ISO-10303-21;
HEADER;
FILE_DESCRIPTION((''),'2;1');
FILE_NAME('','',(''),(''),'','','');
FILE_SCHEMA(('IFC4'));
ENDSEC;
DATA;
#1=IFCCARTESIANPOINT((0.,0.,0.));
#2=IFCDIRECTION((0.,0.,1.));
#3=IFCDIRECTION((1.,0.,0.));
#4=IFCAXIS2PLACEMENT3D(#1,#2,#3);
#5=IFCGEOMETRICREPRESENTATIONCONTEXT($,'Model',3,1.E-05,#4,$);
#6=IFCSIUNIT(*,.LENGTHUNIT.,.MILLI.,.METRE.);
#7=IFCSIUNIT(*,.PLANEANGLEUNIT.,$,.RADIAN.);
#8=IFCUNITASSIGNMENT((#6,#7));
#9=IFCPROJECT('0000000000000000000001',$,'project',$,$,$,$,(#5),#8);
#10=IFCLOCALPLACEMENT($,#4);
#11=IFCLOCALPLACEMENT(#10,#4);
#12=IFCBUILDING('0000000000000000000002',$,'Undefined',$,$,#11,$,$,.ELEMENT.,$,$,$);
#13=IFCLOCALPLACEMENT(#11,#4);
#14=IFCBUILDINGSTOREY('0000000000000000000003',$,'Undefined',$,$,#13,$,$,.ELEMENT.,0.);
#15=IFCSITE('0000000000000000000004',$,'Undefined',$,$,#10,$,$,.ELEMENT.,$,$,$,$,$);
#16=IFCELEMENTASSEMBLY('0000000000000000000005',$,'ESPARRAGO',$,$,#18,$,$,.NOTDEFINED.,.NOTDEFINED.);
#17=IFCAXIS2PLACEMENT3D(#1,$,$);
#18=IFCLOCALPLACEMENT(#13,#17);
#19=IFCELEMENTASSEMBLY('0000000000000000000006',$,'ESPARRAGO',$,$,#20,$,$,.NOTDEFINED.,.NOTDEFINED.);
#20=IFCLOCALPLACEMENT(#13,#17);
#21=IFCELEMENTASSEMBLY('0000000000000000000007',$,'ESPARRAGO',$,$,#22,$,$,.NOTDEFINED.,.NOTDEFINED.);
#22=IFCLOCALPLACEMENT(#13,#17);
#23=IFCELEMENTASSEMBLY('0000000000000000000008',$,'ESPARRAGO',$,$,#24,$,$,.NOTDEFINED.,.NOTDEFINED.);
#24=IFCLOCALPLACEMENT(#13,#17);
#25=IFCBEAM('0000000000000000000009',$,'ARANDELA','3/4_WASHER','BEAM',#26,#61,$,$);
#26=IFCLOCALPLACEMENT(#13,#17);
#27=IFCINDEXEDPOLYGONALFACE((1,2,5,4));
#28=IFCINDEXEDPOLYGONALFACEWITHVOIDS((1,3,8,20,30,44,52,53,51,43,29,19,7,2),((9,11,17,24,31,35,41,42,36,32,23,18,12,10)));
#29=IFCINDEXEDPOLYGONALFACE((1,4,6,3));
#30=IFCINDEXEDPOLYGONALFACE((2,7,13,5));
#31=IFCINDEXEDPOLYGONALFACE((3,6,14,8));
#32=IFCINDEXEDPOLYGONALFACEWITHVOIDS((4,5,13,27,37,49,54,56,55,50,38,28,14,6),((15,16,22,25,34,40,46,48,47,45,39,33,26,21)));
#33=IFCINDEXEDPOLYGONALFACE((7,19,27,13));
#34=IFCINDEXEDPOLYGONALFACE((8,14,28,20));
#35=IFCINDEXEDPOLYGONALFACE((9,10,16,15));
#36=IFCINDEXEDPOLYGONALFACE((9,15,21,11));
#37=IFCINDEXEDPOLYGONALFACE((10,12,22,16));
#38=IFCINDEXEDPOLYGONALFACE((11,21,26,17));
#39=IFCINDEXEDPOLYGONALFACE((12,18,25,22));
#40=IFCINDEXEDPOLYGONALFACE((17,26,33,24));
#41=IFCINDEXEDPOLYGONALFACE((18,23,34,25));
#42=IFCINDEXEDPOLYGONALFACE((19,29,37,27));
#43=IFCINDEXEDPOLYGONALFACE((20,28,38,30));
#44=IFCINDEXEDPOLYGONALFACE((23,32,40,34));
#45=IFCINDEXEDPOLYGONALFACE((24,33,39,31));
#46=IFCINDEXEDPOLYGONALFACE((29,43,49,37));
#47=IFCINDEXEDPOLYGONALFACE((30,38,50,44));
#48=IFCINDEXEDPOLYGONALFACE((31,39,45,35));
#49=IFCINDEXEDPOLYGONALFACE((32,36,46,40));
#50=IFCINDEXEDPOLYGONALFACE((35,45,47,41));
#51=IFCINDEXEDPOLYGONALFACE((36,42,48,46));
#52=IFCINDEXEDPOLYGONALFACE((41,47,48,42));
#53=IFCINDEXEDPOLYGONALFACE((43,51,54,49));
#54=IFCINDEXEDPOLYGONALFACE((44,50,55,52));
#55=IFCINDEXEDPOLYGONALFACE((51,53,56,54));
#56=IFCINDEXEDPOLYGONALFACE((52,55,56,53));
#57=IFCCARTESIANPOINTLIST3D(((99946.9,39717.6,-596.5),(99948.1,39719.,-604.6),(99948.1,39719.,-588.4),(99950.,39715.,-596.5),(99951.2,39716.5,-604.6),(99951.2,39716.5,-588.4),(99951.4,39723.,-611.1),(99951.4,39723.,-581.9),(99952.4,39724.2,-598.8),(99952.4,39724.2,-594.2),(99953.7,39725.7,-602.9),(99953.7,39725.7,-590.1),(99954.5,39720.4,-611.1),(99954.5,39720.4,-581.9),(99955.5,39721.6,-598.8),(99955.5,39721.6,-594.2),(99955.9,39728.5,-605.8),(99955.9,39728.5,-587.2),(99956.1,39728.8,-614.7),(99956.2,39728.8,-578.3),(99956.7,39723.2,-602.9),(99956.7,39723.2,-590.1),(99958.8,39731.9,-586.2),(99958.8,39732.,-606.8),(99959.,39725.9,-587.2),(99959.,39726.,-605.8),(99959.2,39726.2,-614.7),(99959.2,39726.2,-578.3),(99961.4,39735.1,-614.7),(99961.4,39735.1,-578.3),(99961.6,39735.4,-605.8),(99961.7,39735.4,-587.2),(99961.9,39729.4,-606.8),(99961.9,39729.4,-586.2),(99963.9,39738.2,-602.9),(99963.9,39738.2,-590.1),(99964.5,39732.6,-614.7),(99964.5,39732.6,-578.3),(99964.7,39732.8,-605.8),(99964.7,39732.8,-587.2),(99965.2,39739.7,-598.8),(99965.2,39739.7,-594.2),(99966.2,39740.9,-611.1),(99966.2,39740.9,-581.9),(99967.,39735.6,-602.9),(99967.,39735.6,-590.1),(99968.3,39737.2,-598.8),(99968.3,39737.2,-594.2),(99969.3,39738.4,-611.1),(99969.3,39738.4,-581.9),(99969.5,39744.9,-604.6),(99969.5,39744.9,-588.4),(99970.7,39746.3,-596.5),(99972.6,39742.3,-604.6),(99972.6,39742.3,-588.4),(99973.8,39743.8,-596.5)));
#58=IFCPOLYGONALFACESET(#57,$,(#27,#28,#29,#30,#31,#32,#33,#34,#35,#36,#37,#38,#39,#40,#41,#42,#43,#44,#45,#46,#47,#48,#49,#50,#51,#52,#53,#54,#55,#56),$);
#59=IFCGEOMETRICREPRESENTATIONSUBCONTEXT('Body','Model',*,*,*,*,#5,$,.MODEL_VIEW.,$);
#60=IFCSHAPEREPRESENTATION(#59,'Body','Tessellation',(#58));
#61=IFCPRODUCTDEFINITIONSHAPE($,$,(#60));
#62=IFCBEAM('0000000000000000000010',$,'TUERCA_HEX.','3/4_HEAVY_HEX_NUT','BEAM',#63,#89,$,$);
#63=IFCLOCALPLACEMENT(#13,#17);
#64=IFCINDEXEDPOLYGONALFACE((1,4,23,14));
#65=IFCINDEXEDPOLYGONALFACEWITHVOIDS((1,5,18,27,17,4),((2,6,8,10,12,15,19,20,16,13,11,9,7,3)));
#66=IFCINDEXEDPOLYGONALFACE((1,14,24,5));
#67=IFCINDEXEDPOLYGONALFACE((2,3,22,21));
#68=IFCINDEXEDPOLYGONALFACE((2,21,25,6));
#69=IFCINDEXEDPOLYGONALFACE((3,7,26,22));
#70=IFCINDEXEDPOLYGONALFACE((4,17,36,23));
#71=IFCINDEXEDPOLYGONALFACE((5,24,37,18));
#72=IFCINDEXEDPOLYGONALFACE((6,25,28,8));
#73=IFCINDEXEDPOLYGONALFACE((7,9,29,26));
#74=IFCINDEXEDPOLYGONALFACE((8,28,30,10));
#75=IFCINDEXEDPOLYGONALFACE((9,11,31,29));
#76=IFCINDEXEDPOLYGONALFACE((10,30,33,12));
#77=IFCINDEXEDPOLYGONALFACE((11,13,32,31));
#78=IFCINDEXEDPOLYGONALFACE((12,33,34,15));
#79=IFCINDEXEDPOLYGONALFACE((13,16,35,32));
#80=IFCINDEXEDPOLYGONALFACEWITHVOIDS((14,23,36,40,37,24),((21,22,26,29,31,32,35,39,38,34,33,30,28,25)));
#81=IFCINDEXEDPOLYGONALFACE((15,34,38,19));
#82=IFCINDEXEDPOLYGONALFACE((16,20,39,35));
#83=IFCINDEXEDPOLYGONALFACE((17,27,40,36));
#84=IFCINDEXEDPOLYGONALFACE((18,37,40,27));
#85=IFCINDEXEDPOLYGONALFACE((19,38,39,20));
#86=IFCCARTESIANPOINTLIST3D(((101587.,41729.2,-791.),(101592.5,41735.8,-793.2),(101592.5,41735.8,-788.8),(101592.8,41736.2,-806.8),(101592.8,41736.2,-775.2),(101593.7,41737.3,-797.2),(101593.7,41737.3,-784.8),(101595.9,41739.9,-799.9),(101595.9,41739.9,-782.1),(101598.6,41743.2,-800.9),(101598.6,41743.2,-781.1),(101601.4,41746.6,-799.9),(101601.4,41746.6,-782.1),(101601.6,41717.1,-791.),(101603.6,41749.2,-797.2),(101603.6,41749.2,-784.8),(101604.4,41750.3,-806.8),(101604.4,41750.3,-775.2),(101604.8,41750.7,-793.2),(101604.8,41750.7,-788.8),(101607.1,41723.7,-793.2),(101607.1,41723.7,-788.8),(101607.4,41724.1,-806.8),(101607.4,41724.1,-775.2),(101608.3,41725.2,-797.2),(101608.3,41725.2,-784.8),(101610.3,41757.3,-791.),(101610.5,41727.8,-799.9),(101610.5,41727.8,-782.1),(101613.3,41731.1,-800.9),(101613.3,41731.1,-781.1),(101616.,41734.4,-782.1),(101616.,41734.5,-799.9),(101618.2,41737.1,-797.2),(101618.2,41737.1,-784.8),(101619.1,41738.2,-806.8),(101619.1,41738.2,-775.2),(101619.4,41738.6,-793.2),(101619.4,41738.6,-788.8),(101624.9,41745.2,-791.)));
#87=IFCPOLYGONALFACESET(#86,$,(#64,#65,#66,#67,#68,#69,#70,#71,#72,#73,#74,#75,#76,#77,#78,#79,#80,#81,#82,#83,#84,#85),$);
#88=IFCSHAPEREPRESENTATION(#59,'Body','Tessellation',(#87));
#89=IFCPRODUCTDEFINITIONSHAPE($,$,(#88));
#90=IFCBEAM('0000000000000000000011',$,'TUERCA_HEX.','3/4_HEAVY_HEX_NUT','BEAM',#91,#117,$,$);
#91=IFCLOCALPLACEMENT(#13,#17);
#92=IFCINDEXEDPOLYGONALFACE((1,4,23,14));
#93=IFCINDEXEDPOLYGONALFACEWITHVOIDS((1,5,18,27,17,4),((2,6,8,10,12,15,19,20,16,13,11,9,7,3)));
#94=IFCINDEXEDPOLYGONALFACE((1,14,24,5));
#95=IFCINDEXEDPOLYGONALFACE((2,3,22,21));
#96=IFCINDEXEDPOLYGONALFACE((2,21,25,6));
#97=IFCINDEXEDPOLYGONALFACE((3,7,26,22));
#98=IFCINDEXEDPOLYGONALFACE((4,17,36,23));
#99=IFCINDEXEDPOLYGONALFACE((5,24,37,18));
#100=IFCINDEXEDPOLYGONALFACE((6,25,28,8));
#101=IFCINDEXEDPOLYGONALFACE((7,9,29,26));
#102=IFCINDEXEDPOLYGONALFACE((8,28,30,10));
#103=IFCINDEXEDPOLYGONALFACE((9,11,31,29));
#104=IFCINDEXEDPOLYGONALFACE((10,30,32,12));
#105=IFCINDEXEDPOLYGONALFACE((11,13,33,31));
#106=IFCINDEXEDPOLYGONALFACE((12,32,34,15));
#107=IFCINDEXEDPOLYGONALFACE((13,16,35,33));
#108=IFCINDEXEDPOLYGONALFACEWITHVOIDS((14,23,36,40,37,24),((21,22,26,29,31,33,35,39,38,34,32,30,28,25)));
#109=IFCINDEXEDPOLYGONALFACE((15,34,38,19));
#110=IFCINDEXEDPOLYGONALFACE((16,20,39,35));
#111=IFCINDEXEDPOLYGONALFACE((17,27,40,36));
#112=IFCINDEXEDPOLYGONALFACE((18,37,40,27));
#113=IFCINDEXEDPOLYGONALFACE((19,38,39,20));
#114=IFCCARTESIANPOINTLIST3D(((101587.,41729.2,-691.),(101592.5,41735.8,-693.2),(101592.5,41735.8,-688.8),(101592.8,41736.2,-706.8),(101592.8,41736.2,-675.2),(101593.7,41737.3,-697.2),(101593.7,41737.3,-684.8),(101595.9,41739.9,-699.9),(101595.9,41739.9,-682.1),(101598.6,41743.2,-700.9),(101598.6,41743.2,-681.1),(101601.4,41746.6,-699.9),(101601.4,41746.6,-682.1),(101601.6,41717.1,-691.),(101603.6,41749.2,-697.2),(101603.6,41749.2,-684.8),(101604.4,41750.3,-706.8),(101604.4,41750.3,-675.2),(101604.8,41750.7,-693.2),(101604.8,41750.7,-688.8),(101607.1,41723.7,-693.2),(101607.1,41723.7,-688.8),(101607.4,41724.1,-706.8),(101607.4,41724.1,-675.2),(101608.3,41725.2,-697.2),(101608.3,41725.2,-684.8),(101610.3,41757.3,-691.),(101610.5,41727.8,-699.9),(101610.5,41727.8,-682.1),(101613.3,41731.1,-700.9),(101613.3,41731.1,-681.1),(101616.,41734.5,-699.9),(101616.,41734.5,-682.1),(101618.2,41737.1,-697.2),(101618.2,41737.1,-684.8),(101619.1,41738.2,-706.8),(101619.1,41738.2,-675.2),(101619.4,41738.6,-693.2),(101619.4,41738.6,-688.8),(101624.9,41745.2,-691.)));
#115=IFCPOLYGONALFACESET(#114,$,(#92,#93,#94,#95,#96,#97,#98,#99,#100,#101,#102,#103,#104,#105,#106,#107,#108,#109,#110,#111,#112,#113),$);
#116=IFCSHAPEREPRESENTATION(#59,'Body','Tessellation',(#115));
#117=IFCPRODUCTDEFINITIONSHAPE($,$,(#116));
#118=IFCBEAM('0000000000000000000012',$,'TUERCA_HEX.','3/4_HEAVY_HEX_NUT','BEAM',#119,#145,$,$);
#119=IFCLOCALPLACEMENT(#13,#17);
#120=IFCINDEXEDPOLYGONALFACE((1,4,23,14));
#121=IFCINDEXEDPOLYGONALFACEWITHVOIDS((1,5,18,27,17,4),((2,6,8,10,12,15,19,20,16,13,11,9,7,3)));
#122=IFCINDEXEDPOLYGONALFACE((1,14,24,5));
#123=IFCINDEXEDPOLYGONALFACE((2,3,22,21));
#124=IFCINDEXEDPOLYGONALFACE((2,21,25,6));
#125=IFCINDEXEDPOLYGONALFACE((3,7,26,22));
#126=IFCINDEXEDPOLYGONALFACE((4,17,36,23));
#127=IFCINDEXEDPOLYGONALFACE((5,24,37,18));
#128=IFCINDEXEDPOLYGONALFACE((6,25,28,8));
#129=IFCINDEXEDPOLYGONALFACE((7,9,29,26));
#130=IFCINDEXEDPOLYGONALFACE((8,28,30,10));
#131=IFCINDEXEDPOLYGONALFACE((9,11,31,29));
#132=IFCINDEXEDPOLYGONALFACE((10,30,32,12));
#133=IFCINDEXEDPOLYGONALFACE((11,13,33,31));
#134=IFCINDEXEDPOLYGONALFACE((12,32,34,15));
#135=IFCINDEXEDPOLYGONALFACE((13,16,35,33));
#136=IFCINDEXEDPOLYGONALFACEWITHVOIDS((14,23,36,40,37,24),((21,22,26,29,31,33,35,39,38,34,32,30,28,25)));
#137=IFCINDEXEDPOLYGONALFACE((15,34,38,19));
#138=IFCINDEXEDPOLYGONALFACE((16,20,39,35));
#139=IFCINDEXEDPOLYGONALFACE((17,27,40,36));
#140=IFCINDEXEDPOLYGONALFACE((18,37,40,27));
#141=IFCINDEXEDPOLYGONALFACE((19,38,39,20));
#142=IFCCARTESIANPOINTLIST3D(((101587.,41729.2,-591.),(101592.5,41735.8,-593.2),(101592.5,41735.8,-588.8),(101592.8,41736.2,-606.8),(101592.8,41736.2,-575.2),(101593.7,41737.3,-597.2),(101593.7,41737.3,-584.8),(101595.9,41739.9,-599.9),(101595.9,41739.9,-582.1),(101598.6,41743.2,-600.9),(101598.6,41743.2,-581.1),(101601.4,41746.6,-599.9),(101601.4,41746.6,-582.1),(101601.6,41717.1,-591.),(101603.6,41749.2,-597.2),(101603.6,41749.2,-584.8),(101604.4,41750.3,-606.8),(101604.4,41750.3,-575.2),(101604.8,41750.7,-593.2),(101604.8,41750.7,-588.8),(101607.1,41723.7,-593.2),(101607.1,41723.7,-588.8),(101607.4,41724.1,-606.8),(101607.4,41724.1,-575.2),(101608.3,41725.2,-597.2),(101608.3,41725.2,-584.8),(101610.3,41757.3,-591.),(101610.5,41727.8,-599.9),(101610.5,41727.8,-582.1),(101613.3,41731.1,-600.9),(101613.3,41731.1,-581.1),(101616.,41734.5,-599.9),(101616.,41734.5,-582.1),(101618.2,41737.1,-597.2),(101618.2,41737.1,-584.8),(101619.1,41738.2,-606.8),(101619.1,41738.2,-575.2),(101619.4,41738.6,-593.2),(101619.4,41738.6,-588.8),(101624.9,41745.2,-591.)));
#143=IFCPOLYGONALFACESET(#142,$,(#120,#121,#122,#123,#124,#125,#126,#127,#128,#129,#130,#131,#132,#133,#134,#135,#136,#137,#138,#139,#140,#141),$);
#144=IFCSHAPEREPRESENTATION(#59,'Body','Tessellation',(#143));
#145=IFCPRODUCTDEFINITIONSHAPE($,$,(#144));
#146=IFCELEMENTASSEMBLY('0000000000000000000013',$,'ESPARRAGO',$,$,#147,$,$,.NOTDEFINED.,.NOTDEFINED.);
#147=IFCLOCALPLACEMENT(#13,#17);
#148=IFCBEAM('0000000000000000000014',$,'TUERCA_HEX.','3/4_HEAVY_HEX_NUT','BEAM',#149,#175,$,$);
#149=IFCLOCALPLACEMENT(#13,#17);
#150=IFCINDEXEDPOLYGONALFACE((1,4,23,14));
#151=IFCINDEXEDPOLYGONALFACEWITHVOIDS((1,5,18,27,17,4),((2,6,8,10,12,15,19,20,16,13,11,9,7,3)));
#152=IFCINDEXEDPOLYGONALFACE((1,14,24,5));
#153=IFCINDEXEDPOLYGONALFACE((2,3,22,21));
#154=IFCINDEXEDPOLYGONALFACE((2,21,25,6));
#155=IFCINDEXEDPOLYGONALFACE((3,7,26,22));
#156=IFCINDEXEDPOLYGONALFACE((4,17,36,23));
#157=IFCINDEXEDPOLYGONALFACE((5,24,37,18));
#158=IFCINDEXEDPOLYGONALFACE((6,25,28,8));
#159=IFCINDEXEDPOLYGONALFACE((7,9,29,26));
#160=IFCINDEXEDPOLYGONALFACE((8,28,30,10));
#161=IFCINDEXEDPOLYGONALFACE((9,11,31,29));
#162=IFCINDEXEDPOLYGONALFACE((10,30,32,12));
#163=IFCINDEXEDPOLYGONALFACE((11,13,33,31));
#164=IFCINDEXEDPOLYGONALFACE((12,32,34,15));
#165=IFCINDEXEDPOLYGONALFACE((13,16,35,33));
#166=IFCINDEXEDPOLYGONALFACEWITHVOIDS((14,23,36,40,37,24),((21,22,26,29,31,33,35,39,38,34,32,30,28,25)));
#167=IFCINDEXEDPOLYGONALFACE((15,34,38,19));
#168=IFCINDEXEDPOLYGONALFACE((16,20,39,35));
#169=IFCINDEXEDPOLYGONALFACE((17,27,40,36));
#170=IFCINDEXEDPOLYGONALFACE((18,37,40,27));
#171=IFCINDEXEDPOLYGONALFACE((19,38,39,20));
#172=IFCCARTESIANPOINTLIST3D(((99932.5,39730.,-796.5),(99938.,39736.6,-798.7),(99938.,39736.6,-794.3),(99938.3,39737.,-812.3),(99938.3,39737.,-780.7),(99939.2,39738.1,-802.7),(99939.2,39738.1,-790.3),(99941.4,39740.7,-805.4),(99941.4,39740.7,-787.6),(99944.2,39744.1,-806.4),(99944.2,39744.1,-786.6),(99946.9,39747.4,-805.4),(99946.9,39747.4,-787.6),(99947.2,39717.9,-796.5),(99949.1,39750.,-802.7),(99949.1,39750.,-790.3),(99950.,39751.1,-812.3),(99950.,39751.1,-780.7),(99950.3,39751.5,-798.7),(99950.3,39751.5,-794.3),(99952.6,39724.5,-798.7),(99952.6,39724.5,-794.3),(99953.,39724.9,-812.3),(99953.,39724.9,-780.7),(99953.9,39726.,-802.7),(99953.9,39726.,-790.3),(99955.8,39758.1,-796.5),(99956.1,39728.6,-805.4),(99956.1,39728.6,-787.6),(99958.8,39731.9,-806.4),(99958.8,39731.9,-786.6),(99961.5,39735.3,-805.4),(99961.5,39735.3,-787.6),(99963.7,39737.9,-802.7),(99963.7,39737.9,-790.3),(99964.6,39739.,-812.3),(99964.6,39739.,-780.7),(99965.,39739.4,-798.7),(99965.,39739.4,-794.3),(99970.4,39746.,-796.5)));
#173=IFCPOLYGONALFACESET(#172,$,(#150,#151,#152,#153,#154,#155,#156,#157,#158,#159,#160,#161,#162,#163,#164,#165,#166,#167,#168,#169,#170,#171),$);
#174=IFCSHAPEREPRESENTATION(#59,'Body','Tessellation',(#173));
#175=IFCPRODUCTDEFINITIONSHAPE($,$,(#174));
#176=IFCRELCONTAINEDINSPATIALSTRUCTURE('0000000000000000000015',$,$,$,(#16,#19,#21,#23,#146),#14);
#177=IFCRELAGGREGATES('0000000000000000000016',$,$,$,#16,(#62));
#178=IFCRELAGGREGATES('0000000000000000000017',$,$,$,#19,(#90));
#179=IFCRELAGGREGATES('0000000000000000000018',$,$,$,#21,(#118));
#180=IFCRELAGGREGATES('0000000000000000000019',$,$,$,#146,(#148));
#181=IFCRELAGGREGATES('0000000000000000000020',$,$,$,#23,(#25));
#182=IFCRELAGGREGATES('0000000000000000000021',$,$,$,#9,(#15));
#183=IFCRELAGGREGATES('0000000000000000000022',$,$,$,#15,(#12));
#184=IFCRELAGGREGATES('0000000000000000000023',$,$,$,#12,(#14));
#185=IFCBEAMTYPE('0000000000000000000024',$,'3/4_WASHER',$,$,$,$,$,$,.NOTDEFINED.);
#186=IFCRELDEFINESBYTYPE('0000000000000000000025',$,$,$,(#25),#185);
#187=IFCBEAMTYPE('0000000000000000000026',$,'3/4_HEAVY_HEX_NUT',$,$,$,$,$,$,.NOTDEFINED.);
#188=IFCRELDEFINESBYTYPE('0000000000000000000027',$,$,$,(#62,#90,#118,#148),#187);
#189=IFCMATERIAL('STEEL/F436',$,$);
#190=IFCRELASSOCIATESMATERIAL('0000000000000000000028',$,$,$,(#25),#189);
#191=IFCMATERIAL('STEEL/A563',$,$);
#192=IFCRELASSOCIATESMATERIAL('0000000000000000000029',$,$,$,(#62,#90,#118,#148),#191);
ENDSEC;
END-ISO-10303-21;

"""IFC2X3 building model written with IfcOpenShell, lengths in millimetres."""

from ifc_helpers import new_model, si_unit, frame, origin_with_axes, place, context, subcontext, project, spatial, polyline, outline, extrude, material, type_object, element, aggregate, save


model = new_model("IFC2X3")

# Units and contexts
model_context = context("Model", 3, precision=1e-05, world=origin_with_axes())
body_context = subcontext(model_context, "Body", "Model", "MODEL_VIEW")
ifc_project = project(units=[si_unit("LENGTHUNIT", "METRE", prefix="MILLI"), si_unit("PLANEANGLEUNIT", "RADIAN")], contexts=[model_context])

# Site, building, storey
site_placement = place(None, origin_with_axes())
site = spatial("IfcSite", under=ifc_project, at=site_placement, Name="Undefined", CompositionType="ELEMENT")
building_placement = place(site_placement, origin_with_axes())
building = spatial("IfcBuilding", under=site, at=building_placement, Name="Undefined", CompositionType="ELEMENT")
storey_placement = place(building_placement, origin_with_axes())
storey = spatial("IfcBuildingStorey", under=building, at=storey_placement, Name="Undefined", CompositionType="ELEMENT", Elevation=0.0)

# Element assemblies, beam
assembly_1_placement = place(storey_placement, origin_with_axes())
assembly_1 = element("IfcElementAssembly", 1, at=assembly_1_placement, inside=storey, Name="ESPARRAGO", AssemblyPlace="NOTDEFINED", PredefinedType="NOTDEFINED")
ifc_material_1 = material(Name="STEEL/F436")
beam_type_1 = type_object("IfcBeamType", Name="3/4_WASHER", PredefinedType="NOTDEFINED")
assembly_2_placement = place(storey_placement, origin_with_axes())
assembly_2 = element("IfcElementAssembly", 2, at=assembly_2_placement, inside=storey, Name="ESPARRAGO", AssemblyPlace="NOTDEFINED", PredefinedType="NOTDEFINED")
assembly_3_placement = place(storey_placement, origin_with_axes())
assembly_3 = element("IfcElementAssembly", 3, at=assembly_3_placement, inside=storey, Name="ESPARRAGO", AssemblyPlace="NOTDEFINED", PredefinedType="NOTDEFINED")
assembly_4_placement = place(storey_placement, origin_with_axes())
assembly_4 = element("IfcElementAssembly", 4, at=assembly_4_placement, inside=storey, Name="ESPARRAGO", AssemblyPlace="NOTDEFINED", PredefinedType="NOTDEFINED")
beam_1_placement = place(assembly_4_placement, frame((99958.8, 39732.0, -596.5), z_axis=(0.000066, -0.000055, 1.0), x_axis=(0.7704, -0.637561, -0.000086)))
beam_1 = element("IfcBeam", 5, at=beam_1_placement, type_object=beam_type_1, material=ifc_material_1, Name="ARANDELA", Description="3/4_WASHER", ObjectType="BEAM", context=body_context, shape_type="SweptSolid", body=[
    extrude(outline(polyline([(-11.6, -14.6), (-16.8, -8.1), (-18.6, 0.0), (-16.8, 8.1), (-11.6, 14.6), (-4.2, 18.2), (4.2, 18.2), (11.6, 14.6), (16.8, 8.1), (18.6, 0.0), (16.8, -8.1), (11.6, -14.6), (4.2, -18.2), (-4.2, -18.2), (-11.6, -14.6)]), holes=[polyline([(-4.5, 9.3), (-8.1, 6.4), (-10.1, 2.3), (-10.1, -2.3), (-8.1, -6.4), (-4.5, -9.3), (0.0, -10.3), (4.5, -9.3), (8.1, -6.4), (10.1, -2.3), (10.1, 2.3), (8.1, 6.4), (4.5, 9.3), (0.0, 10.3), (-4.5, 9.3)])]), frame((4.0, 0.0, 0.0), z_axis=(-1.0, 0.0, 0.0), x_axis=(0.0, -1.0, 0.0)), (0.0, 0.0, 1.0), 4.0),
])

# Beams
ifc_material_2 = material(Name="STEEL/A563")
beam_type_2 = type_object("IfcBeamType", Name="3/4_HEAVY_HEX_NUT", PredefinedType="NOTDEFINED")
beam_2_placement = place(assembly_1_placement, frame((101598.6, 41743.2, -791.0), z_axis=(0.000012, -0.00001, 1.0), x_axis=(0.7704, -0.637561, -0.000016)))
beam_2 = element("IfcBeam", 6, at=beam_2_placement, type_object=beam_type_2, material=ifc_material_2, Name="TUERCA_HEX.", Description="3/4_HEAVY_HEX_NUT", ObjectType="BEAM", context=body_context, shape_type="SweptSolid", body=[
    extrude(outline(polyline([(9.1, -15.8), (-9.1, -15.8), (-18.3, 0.0), (-9.1, 15.8), (9.1, 15.8), (18.3, 0.0), (9.1, -15.8)]), holes=[polyline([(-4.3, 8.9), (-7.8, 6.2), (-9.7, 2.2), (-9.7, -2.2), (-7.8, -6.2), (-4.3, -8.9), (0.0, -9.9), (4.3, -8.9), (7.8, -6.2), (9.7, -2.2), (9.7, 2.2), (7.8, 6.2), (4.3, 8.9), (0.0, 9.9), (-4.3, 8.9)])]), frame((19.0, 0.0, 0.0), z_axis=(-1.0, 0.0, 0.0), x_axis=(0.0, -1.0, 0.0)), (0.0, 0.0, 1.0), 19.0),
])
beam_3_placement = place(assembly_2_placement, frame((101598.6, 41743.2, -691.0), z_axis=(0.000012, -0.00001, 1.0), x_axis=(0.7704, -0.637561, -0.000016)))
beam_3 = element("IfcBeam", 7, at=beam_3_placement, type_object=beam_type_2, material=ifc_material_2, Name="TUERCA_HEX.", Description="3/4_HEAVY_HEX_NUT", ObjectType="BEAM", context=body_context, shape_type="SweptSolid", body=[
    extrude(outline(polyline([(9.1, -15.8), (-9.1, -15.8), (-18.3, 0.0), (-9.1, 15.8), (9.1, 15.8), (18.3, 0.0), (9.1, -15.8)]), holes=[polyline([(-4.3, 8.9), (-7.8, 6.2), (-9.7, 2.2), (-9.7, -2.2), (-7.8, -6.2), (-4.3, -8.9), (0.0, -9.9), (4.3, -8.9), (7.8, -6.2), (9.7, -2.2), (9.7, 2.2), (7.8, 6.2), (4.3, 8.9), (0.0, 9.9), (-4.3, 8.9)])]), frame((19.0, 0.0, 0.0), z_axis=(-1.0, 0.0, 0.0), x_axis=(0.0, -1.0, 0.0)), (0.0, 0.0, 1.0), 19.0),
])
beam_4_placement = place(assembly_3_placement, frame((101598.6, 41743.2, -591.0), z_axis=(0.000012, -0.00001, 1.0), x_axis=(0.7704, -0.637561, -0.000016)))
beam_4 = element("IfcBeam", 8, at=beam_4_placement, type_object=beam_type_2, material=ifc_material_2, Name="TUERCA_HEX.", Description="3/4_HEAVY_HEX_NUT", ObjectType="BEAM", context=body_context, shape_type="SweptSolid", body=[
    extrude(outline(polyline([(9.1, -15.8), (-9.1, -15.8), (-18.3, 0.0), (-9.1, 15.8), (9.1, 15.8), (18.3, 0.0), (9.1, -15.8)]), holes=[polyline([(-4.3, 8.9), (-7.8, 6.2), (-9.7, 2.2), (-9.7, -2.2), (-7.8, -6.2), (-4.3, -8.9), (0.0, -9.9), (4.3, -8.9), (7.8, -6.2), (9.7, -2.2), (9.7, 2.2), (7.8, 6.2), (4.3, 8.9), (0.0, 9.9), (-4.3, 8.9)])]), frame((19.0, 0.0, 0.0), z_axis=(-1.0, 0.0, 0.0), x_axis=(0.0, -1.0, 0.0)), (0.0, 0.0, 1.0), 19.0),
])

# Element assembly, beam
assembly_5_placement = place(storey_placement, origin_with_axes())
assembly_5 = element("IfcElementAssembly", 9, at=assembly_5_placement, inside=storey, Name="ESPARRAGO", AssemblyPlace="NOTDEFINED", PredefinedType="NOTDEFINED")
beam_5_placement = place(assembly_5_placement, frame((99944.2, 39744.1, -796.5), z_axis=(0.000012, -0.00001, 1.0), x_axis=(0.7704, -0.637561, -0.000016)))
beam_5 = element("IfcBeam", 10, at=beam_5_placement, type_object=beam_type_2, material=ifc_material_2, Name="TUERCA_HEX.", Description="3/4_HEAVY_HEX_NUT", ObjectType="BEAM", context=body_context, shape_type="SweptSolid", body=[
    extrude(outline(polyline([(9.1, -15.8), (-9.1, -15.8), (-18.3, 0.0), (-9.1, 15.8), (9.1, 15.8), (18.3, 0.0), (9.1, -15.8)]), holes=[polyline([(-4.3, 8.9), (-7.8, 6.2), (-9.7, 2.2), (-9.7, -2.2), (-7.8, -6.2), (-4.3, -8.9), (0.0, -9.9), (4.3, -8.9), (7.8, -6.2), (9.7, -2.2), (9.7, 2.2), (7.8, 6.2), (4.3, 8.9), (0.0, 9.9), (-4.3, 8.9)])]), frame((19.0, 0.0, 0.0), z_axis=(-1.0, 0.0, 0.0), x_axis=(0.0, -1.0, 0.0)), (0.0, 0.0, 1.0), 19.0),
])

aggregate(assembly_1, [beam_2])
aggregate(assembly_2, [beam_3])
aggregate(assembly_3, [beam_4])
aggregate(assembly_5, [beam_5])
aggregate(assembly_4, [beam_1])

save(model, "model.ifc")
